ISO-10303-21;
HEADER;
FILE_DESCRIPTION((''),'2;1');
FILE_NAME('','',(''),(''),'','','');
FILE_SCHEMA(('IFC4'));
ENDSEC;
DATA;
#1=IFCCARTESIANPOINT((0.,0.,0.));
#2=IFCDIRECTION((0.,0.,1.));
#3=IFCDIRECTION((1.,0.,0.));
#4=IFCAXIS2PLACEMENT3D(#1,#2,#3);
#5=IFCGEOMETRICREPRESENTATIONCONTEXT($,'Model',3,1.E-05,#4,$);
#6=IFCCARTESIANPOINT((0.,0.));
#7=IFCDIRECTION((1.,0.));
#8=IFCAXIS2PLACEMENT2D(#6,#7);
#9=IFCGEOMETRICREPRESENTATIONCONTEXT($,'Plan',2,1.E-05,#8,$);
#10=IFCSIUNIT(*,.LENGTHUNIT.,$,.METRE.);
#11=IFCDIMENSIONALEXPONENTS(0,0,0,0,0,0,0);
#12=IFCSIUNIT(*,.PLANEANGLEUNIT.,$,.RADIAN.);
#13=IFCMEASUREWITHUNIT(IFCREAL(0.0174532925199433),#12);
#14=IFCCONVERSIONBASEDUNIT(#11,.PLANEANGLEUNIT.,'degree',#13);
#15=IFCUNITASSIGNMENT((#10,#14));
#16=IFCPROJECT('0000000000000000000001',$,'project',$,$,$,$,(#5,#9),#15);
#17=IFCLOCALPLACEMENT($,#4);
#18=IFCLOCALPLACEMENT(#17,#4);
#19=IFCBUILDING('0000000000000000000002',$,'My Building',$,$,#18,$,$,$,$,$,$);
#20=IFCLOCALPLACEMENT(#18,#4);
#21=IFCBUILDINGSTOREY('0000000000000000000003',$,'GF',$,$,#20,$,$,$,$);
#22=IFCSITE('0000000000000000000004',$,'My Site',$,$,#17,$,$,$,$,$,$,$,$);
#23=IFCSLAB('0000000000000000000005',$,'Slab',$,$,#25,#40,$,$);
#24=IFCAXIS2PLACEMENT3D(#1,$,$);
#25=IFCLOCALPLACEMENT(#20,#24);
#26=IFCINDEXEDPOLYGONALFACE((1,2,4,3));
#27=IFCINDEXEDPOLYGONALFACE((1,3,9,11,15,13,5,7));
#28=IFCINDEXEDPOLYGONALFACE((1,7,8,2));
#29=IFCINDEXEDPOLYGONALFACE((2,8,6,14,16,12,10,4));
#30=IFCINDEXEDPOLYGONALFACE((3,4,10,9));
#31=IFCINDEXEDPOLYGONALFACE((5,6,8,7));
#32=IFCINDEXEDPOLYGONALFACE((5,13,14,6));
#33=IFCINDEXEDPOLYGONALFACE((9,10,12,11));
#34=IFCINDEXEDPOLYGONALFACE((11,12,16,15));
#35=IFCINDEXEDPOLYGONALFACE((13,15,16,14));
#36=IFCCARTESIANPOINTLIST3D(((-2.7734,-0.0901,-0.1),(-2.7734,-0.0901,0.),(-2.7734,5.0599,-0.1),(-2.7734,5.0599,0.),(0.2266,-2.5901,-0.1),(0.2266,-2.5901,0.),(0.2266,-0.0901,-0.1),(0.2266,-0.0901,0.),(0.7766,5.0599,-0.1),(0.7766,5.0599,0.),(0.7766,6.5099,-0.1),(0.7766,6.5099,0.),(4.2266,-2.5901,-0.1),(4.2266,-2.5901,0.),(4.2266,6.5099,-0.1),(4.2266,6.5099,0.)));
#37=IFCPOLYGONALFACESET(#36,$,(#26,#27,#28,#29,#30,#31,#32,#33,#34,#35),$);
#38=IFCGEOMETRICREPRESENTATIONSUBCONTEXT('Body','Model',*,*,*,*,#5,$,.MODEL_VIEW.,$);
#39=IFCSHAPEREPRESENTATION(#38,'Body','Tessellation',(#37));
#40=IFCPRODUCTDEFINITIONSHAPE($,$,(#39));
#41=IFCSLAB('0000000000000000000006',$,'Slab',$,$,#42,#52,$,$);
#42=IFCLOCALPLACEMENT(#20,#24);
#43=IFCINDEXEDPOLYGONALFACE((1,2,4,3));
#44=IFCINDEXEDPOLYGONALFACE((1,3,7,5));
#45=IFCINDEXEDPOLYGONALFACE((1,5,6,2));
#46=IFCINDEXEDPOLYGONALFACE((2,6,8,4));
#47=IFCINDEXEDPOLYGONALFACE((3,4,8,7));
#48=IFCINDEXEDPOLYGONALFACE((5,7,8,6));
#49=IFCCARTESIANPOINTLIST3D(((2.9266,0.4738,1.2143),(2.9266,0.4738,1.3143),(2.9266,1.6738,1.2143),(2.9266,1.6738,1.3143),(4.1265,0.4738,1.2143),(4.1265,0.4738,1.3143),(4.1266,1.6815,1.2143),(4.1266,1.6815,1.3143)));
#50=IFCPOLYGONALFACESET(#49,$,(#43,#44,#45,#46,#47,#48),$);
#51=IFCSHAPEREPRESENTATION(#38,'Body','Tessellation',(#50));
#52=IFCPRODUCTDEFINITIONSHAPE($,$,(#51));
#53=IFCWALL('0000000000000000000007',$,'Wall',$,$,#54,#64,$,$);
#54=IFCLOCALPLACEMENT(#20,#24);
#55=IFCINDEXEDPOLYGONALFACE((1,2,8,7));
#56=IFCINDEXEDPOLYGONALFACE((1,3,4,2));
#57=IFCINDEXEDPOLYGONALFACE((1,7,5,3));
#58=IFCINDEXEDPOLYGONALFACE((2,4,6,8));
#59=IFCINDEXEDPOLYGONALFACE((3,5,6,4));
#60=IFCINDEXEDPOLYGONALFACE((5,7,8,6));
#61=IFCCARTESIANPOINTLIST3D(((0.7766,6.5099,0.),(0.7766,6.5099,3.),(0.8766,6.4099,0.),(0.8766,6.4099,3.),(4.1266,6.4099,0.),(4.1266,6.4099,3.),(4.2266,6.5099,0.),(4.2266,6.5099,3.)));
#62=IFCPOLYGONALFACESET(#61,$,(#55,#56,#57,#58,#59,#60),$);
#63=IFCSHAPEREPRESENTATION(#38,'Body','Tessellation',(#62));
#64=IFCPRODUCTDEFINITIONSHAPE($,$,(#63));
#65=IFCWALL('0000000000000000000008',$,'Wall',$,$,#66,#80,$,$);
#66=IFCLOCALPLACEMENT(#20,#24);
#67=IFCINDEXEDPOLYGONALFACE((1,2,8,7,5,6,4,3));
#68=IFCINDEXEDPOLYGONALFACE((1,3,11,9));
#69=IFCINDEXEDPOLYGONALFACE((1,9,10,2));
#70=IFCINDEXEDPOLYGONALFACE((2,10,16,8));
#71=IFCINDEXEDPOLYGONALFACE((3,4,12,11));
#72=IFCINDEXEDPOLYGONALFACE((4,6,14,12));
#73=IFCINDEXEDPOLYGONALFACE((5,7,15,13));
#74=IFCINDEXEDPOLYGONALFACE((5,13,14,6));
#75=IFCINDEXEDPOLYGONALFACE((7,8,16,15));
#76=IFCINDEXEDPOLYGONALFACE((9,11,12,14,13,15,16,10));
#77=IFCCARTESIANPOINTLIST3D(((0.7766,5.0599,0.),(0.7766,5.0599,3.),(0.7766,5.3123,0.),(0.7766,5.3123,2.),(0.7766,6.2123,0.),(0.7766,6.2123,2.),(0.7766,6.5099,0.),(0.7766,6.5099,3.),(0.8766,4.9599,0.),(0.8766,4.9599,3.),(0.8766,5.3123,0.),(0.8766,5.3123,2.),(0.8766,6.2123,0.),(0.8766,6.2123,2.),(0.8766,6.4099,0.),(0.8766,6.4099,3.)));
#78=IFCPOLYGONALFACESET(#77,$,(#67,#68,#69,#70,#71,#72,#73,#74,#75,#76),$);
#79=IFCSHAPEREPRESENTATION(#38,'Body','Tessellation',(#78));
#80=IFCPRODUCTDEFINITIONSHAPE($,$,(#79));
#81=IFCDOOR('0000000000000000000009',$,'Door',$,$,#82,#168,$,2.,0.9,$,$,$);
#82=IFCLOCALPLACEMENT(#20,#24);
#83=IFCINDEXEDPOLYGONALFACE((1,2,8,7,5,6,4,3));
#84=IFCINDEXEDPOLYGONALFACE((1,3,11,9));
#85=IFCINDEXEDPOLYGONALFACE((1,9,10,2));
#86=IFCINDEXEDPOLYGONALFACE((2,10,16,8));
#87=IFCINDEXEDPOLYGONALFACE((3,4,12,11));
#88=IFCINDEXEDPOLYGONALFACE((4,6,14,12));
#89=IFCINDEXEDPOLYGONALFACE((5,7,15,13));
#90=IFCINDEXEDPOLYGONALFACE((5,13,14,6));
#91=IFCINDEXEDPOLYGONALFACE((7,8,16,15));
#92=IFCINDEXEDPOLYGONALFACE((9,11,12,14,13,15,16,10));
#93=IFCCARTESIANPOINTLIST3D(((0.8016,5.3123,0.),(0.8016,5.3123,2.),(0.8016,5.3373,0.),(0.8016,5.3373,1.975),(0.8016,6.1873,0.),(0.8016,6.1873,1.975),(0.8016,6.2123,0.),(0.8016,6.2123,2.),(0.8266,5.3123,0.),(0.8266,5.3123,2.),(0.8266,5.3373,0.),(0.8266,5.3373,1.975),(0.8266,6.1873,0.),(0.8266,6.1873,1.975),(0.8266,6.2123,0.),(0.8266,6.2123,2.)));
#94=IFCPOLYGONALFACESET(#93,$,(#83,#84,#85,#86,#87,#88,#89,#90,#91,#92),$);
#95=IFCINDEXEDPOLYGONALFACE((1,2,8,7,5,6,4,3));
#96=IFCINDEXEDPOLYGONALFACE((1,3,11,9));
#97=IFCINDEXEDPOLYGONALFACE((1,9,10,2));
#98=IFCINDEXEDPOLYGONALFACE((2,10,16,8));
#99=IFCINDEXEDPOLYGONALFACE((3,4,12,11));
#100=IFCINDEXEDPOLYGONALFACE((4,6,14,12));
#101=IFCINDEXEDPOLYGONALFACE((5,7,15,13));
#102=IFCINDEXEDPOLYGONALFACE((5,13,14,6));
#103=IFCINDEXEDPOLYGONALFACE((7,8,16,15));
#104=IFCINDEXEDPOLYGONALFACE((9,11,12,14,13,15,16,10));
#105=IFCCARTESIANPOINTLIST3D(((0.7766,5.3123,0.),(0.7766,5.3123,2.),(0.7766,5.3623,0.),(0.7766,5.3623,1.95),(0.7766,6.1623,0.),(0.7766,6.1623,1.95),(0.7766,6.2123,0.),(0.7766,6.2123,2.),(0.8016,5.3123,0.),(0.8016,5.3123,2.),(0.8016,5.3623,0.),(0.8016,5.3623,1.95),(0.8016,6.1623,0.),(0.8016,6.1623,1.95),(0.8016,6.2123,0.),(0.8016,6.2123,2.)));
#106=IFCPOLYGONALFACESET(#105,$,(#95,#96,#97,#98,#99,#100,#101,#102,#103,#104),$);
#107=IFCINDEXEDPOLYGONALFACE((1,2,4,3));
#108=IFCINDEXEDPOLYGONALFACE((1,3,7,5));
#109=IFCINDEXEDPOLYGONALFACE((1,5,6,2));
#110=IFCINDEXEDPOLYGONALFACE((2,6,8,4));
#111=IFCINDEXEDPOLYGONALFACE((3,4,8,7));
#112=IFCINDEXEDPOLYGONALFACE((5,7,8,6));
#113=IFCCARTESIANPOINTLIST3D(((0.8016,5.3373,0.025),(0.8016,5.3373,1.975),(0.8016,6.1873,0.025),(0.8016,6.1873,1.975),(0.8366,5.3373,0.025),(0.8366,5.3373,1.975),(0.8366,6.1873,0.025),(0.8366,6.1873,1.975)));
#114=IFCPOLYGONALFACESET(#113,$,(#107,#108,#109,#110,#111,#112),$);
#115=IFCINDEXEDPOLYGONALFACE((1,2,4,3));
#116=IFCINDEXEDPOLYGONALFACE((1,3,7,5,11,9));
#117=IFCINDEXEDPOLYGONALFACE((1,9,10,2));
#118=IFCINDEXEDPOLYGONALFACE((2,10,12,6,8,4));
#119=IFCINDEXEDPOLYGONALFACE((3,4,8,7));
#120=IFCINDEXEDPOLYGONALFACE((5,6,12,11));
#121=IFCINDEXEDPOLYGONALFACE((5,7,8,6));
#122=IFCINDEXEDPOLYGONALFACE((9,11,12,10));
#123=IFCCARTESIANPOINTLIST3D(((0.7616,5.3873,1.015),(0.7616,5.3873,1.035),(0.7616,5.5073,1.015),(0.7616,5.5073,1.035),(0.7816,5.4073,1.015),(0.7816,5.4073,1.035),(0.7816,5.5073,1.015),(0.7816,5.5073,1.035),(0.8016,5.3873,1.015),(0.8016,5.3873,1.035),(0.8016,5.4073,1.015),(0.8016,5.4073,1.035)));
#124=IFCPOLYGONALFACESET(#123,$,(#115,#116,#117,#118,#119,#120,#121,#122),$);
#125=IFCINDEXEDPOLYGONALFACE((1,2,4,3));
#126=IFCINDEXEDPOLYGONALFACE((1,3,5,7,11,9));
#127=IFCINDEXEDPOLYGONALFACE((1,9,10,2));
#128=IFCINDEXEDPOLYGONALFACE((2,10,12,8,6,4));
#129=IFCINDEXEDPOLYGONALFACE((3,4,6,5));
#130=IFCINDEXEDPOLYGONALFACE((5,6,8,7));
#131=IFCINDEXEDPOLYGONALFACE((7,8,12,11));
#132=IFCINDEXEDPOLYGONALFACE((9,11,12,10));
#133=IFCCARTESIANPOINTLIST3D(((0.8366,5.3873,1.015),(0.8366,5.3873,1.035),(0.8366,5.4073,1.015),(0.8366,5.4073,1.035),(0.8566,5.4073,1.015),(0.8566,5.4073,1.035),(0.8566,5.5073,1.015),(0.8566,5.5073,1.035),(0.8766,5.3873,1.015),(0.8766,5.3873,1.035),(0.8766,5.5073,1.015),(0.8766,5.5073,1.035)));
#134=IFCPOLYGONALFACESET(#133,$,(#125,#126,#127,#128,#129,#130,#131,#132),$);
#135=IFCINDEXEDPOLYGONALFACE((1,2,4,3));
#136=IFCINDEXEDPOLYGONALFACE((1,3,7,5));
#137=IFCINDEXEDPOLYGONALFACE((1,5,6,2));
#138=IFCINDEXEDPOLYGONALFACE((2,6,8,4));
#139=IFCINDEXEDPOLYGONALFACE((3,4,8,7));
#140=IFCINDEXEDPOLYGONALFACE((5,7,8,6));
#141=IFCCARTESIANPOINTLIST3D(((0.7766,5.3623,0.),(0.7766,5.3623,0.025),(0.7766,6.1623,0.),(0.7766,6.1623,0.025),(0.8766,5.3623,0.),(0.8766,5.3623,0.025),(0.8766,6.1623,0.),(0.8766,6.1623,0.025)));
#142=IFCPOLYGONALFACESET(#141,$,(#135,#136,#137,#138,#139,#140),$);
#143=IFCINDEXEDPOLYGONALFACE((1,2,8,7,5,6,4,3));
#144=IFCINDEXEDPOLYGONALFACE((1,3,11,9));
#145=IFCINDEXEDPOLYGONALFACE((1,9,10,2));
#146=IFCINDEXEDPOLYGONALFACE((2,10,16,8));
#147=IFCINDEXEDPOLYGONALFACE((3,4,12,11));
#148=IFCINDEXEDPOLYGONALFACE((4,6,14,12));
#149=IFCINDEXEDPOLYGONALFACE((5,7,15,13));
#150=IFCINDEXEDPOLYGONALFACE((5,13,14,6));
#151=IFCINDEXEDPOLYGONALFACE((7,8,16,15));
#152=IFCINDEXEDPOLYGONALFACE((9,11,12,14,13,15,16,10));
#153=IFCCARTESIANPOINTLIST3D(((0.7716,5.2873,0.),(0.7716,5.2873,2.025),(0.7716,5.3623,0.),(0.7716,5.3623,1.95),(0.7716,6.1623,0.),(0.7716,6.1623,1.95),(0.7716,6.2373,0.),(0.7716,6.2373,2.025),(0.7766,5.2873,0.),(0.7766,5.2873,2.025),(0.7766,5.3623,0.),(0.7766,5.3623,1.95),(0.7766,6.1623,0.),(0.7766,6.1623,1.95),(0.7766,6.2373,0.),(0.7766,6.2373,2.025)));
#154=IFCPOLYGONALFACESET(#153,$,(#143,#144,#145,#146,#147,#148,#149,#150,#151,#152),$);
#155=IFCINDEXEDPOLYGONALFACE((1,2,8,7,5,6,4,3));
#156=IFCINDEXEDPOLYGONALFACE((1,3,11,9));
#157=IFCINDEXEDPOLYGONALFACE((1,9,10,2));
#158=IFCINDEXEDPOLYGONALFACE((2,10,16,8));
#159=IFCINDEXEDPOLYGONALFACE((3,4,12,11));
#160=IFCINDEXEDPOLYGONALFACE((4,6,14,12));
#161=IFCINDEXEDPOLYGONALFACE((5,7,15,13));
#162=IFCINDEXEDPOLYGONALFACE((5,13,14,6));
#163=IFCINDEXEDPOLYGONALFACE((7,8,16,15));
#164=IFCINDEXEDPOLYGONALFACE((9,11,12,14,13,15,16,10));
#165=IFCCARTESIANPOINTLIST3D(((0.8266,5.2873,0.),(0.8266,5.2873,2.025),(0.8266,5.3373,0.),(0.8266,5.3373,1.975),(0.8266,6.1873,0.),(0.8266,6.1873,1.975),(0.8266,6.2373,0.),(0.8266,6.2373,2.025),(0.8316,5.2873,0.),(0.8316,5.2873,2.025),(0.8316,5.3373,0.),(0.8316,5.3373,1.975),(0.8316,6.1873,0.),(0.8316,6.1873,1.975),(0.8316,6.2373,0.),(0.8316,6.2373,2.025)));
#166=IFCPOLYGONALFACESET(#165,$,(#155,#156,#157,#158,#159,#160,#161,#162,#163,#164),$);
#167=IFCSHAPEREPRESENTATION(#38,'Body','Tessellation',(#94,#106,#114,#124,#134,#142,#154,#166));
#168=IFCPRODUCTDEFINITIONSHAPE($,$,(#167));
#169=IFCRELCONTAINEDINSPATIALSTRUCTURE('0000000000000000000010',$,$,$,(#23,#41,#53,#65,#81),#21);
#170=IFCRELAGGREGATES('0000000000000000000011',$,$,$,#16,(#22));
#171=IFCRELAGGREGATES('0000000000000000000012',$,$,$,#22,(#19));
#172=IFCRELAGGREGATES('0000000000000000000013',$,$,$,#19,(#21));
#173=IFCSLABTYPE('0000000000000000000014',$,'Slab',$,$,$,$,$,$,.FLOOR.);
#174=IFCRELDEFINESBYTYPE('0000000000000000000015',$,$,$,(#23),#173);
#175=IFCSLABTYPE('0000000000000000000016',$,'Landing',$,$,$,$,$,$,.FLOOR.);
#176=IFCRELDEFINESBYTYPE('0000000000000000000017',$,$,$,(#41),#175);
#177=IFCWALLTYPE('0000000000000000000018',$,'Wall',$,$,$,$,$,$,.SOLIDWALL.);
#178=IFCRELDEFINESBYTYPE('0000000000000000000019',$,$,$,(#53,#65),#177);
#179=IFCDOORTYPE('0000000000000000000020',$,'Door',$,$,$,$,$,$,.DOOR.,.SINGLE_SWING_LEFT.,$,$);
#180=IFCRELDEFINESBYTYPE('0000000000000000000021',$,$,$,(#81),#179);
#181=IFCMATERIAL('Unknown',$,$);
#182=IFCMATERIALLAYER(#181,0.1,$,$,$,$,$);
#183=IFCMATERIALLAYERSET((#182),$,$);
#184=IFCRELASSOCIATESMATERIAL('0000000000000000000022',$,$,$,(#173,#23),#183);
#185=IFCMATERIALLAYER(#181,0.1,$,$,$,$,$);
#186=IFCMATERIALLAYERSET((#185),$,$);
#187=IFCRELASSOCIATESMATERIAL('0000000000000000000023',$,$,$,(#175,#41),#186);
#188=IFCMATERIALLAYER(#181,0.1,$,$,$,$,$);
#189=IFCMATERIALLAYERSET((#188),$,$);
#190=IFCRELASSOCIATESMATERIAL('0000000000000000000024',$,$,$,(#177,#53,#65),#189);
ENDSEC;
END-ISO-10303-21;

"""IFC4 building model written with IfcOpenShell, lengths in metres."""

from ifc_helpers import new_model, entity, si_unit, converted_unit, frame, origin_with_axes, origin_2d_with_axis, place, context, subcontext, project, spatial, line, indexed_curve, outline, extrude, shape, source, transform, mapped, material, layer, layer_set, layer_usage, type_object, type_shapes, element, fill, save


model = new_model("IFC4")

# Units and contexts
model_context = context("Model", 3, precision=1e-05, world=origin_with_axes())
plan_context = context("Plan", 2, precision=1e-05, world=origin_2d_with_axis())
body_context_1 = subcontext(model_context, "Body", "Model", "MODEL_VIEW")
body_context_2 = subcontext(plan_context, "Body", "Plan", "PLAN_VIEW")
ifc_project = project(units=[si_unit("LENGTHUNIT", "METRE"), converted_unit("PLANEANGLEUNIT", "degree", entity("IfcReal", 0.0174532925199433), si_unit("PLANEANGLEUNIT", "RADIAN"), dimensions=[0, 0, 0, 0, 0, 0, 0])], contexts=[model_context, plan_context])

# Site, building, storey
site_placement = place(None, origin_with_axes())
site = spatial("IfcSite", under=ifc_project, at=site_placement, Name="My Site")
building_placement = place(site_placement, origin_with_axes())
building = spatial("IfcBuilding", under=site, at=building_placement, Name="My Building")
storey_placement = place(building_placement, origin_with_axes())
storey = spatial("IfcBuildingStorey", under=building, at=storey_placement, Name="GF")

# Slabs
ifc_material_1 = material(Name="Unknown")
ifc_layer_1 = layer(ifc_material_1, 0.1)
ifc_layer_set_1 = layer_set([ifc_layer_1])
ifc_layer_usage_1 = layer_usage(ifc_layer_set_1, "AXIS3", "POSITIVE", -0.1)
slab_type_1 = type_object("IfcSlabType", Name="Slab", PredefinedType="FLOOR", material=ifc_layer_set_1)
slab_1_placement = place(storey_placement, frame((4.2266, -2.5901, 0.0), z_axis=(0.0, 0.0, 1.0), x_axis=(1.0, 0.0, 0.0)))
element("IfcSlab", 1, at=slab_1_placement, inside=storey, type_object=slab_type_1, material=ifc_layer_usage_1, Name="Slab", context=body_context_1, shape_type="SweptSolid", body=[
    extrude(outline(indexed_curve([(0.0, 0.0), (0.0, 9.1), (-3.45, 9.1), (-3.45, 7.65), (-7.0, 7.65), (-7.0, 2.5), (-4.0, 2.5), (-4.0, 0.0), (0.0, 0.0)])), frame((0.0, 0.0, -0.1), z_axis=(0.0, 0.0, 1.0), x_axis=(1.0, 0.0, 0.0)), (0.0, 0.0, 1.0), 0.1),
])
ifc_layer_2 = layer(ifc_material_1, 0.1)
ifc_layer_set_2 = layer_set([ifc_layer_2])
ifc_layer_usage_2 = layer_usage(ifc_layer_set_2, "AXIS3", "POSITIVE", -0.1)
slab_type_2 = type_object("IfcSlabType", Name="Landing", PredefinedType="FLOOR", material=ifc_layer_set_2)
slab_2_placement = place(storey_placement, frame((4.1266, 1.6815, 1.3143), z_axis=(0.0, 0.0, 1.0), x_axis=(1.0, 0.0, 0.0)))
element("IfcSlab", 2, at=slab_2_placement, inside=storey, type_object=slab_type_2, material=ifc_layer_usage_2, Name="Slab", context=body_context_1, shape_type="SweptSolid", body=[
    extrude(outline(indexed_curve([(0.0, 0.0), (-1.2, -0.0076), (-1.2, -1.2076), (-0.0001, -1.2076), (0.0, 0.0)])), frame((0.0, 0.0, -0.1), z_axis=(0.0, 0.0, 1.0), x_axis=(1.0, 0.0, 0.0)), (0.0, 0.0, 1.0), 0.1),
])

# Wall
ifc_layer_3 = layer(ifc_material_1, 0.1)
ifc_layer_set_3 = layer_set([ifc_layer_3])
ifc_layer_usage_3 = layer_usage(ifc_layer_set_3, "AXIS2", "POSITIVE", 0.0)
wall_type = type_object("IfcWallType", Name="Wall", PredefinedType="SOLIDWALL", material=ifc_layer_set_3)
wall_1_placement = place(storey_placement, frame((4.2266, 6.5099, 0.0), z_axis=(0.0, 0.0, 1.0), x_axis=(-1.0, 0.0, 0.0)))
element("IfcWall", 3, at=wall_1_placement, inside=storey, type_object=wall_type, material=ifc_layer_usage_3, Name="Wall", context=body_context_1, shape_type="SweptSolid", body=[
    extrude(outline(indexed_curve([(0.0, 0.0), (0.1, 0.1), (3.35, 0.1), (3.45, 0.0)], segments=[line(1, 2, 3, 4, 1)])), origin_with_axes(), (0.0, 0.0, 1.0), 3.0),
])

# Wall, opening, door
ifc_layer_usage_4 = layer_usage(ifc_layer_set_3, "AXIS2", "POSITIVE", 0.0)
wall_2_placement = place(storey_placement, frame((0.7766, 6.5099, 0.0), z_axis=(0.0, 0.0, 1.0), x_axis=(0.0, -1.0, 0.0)))
wall_2 = element("IfcWall", 4, at=wall_2_placement, inside=storey, type_object=wall_type, material=ifc_layer_usage_4, Name="Wall", context=body_context_1, shape_type="SweptSolid", body=[
    extrude(outline(indexed_curve([(0.0, 0.0), (0.1, 0.1), (1.55, 0.1), (1.45, 0.0)], segments=[line(1, 2, 3, 4, 1)])), origin_with_axes(), (0.0, 0.0, 1.0), 3.0),
])
shared_shape_1 = source(origin_with_axes(), body_context_1, "Body", "SweptSolid", [
    extrude(outline(indexed_curve([(0.0, 0.0), (0.9, 0.0), (0.9, 2.0), (0.0, 2.0)], segments=[line(1, 2, 3, 4, 1)])), frame((0.0, -0.6, 0.0), z_axis=(0.0, -1.0, 0.0), x_axis=(1.0, 0.0, 0.0)), (0.0, 0.0, -1.0), 1.2),
])
opening_1_placement = place(wall_2_placement, frame((0.2976, 0.0, 0.0), z_axis=(0.0, 0.0, 1.0), x_axis=(1.0, 0.0, 0.0)))
opening_1 = element("IfcOpeningElement", 5, at=opening_1_placement, cuts=wall_2, PredefinedType="OPENING", context=body_context_1, shape_type="MappedRepresentation", body=[
    mapped(shared_shape_1, transform((0.0, 0.0, 0.0), x_axis=(1.0, 0.0, 0.0), y_axis=(0.0, 1.0, 0.0), z_axis=(0.0, 0.0, 1.0), scale=1.0)),
])
door_type = type_object("IfcDoorType", Name="Door", OperationType="SINGLE_SWING_LEFT", PredefinedType="DOOR")
shared_shape_2 = source(origin_with_axes(), body_context_1, "Body", "SweptSolid", [
    extrude(outline(indexed_curve([(0.0, 0.0), (0.0, 2.0), (0.9, 2.0), (0.9, 0.0), (0.875, 0.0), (0.875, 1.975), (0.025, 1.975), (0.025, 0.0)], segments=[line(1, 2, 3, 4, 5, 6, 7, 8, 1)])), frame((0.0, 0.025, 0.0), z_axis=(0.0, -1.0, 0.0), x_axis=(1.0, 0.0, 0.0)), (0.0, 0.0, -1.0), 0.025),
    extrude(outline(indexed_curve([(0.0, 0.0), (0.0, 2.0), (0.9, 2.0), (0.9, 0.0), (0.85, 0.0), (0.85, 1.95), (0.05, 1.95), (0.05, 0.0)], segments=[line(1, 2, 3, 4, 5, 6, 7, 8, 1)])), frame((0.0, 0.0, 0.0), z_axis=(0.0, -1.0, 0.0), x_axis=(1.0, 0.0, 0.0)), (0.0, 0.0, -1.0), 0.025),
    extrude(outline(indexed_curve([(0.0, 0.0), (0.85, 0.0), (0.85, 0.035), (0.0, 0.035)], segments=[line(1, 2, 3, 4, 1)])), frame((0.025, 0.025, 0.025), z_axis=(0.0, 0.0, 1.0), x_axis=(1.0, 0.0, 0.0)), (0.0, 0.0, 1.0), 1.95),
    extrude(outline(indexed_curve([(0.0, 0.0), (0.0, -0.04), (-0.12, -0.04), (-0.12, -0.02), (-0.02, -0.02), (-0.02, 0.0)], segments=[line(1, 2, 3, 4, 5, 6, 1)])), frame((0.825, 0.025, 1.015), z_axis=(0.0, 0.0, 1.0), x_axis=(1.0, 0.0, 0.0)), (0.0, 0.0, 1.0), 0.02),
    extrude(outline(indexed_curve([(0.0, 0.0), (0.0, 0.04), (-0.12, 0.04), (-0.12, 0.02), (-0.02, 0.02), (-0.02, 0.0)], segments=[line(1, 2, 3, 4, 5, 6, 1)])), frame((0.825, 0.06, 1.015), z_axis=(0.0, 0.0, 1.0), x_axis=(1.0, 0.0, 0.0)), (0.0, 0.0, 1.0), 0.02),
    extrude(outline(indexed_curve([(0.0, 0.0), (0.8, 0.0), (0.8, 0.1), (0.0, 0.1)], segments=[line(1, 2, 3, 4, 1)])), frame((0.05, 0.0, 0.0), z_axis=(0.0, 0.0, 1.0), x_axis=(1.0, 0.0, 0.0)), (0.0, 0.0, 1.0), 0.025),
    extrude(outline(indexed_curve([(0.0, 0.0), (0.0, 2.025), (0.95, 2.025), (0.95, 0.0), (0.875, 0.0), (0.875, 1.95), (0.075, 1.95), (0.075, 0.0)], segments=[line(1, 2, 3, 4, 5, 6, 7, 8, 1)])), frame((-0.025, -0.005, 0.0), z_axis=(0.0, -1.0, 0.0), x_axis=(1.0, 0.0, 0.0)), (0.0, 0.0, -1.0), 0.005),
    extrude(outline(indexed_curve([(0.0, 0.0), (0.0, 2.025), (0.95, 2.025), (0.95, 0.0), (0.9, 0.0), (0.9, 1.975), (0.05, 1.975), (0.05, 0.0)], segments=[line(1, 2, 3, 4, 5, 6, 7, 8, 1)])), frame((-0.025, 0.05, 0.0), z_axis=(0.0, -1.0, 0.0), x_axis=(1.0, 0.0, 0.0)), (0.0, 0.0, -1.0), 0.005),
])
shared_shape_3 = source(origin_with_axes(), body_context_2, "Body", "Curve2D", [
    entity("IfcIndexedPolyCurve", entity("IfcCartesianPointList2D", [[0.0, 0.0], [0.0, 0.05], [0.025, 0.05], [0.025, 0.025], [0.05, 0.025], [0.05, 0.0]]), [entity("IfcLineIndex", [1, 2, 3, 4, 5, 6, 1])]),
    entity("IfcIndexedPolyCurve", entity("IfcCartesianPointList2D", [[0.9, 0.0], [0.9, 0.05], [0.875, 0.05], [0.875, 0.025], [0.85, 0.025], [0.85, 0.0]]), [entity("IfcLineIndex", [1, 2, 3, 4, 5, 6, 1])]),
    entity("IfcTrimmedCurve", entity("IfcEllipse", entity("IfcAxis2Placement2D", entity("IfcCartesianPoint", [0.06, 0.05]), entity("IfcDirection", [1.0, 0.0])), 0.815, 0.85), [entity("IfcCartesianPoint", [0.875, 0.05])], [entity("IfcCartesianPoint", [0.06, 0.9])], True, "CARTESIAN"),
    entity("IfcIndexedPolyCurve", entity("IfcCartesianPointList2D", [[0.025, 0.05], [0.06, 0.05], [0.06, 0.9], [0.025, 0.9]]), [entity("IfcLineIndex", [1, 2, 3, 4, 1])]),
])
type_shapes(door_type, [shared_shape_2, shared_shape_3])
door_1_placement = place(opening_1_placement, frame((0.0, 0.0, 0.0), z_axis=(0.0, 0.0, 1.0), x_axis=(1.0, 0.0, 0.0)))
door_1 = element("IfcDoor", 6, at=door_1_placement, inside=storey, type_object=door_type, Name="Door", OverallHeight=2.0, OverallWidth=0.9, shapes=[
    shape(body_context_1, "Body", "MappedRepresentation", [mapped(shared_shape_2, transform((0.0, 0.0, 0.0), x_axis=(1.0, 0.0, 0.0), y_axis=(0.0, 1.0, 0.0), z_axis=(0.0, 0.0, 1.0), scale=1.0))]),
    shape(body_context_2, "Body", "MappedRepresentation", [mapped(shared_shape_3, transform((0.0, 0.0, 0.0), x_axis=(1.0, 0.0, 0.0), y_axis=(0.0, 1.0, 0.0), z_axis=(0.0, 0.0, 1.0), scale=1.0))]),
])
fill(opening_1, door_1)

save(model, "model.ifc")
